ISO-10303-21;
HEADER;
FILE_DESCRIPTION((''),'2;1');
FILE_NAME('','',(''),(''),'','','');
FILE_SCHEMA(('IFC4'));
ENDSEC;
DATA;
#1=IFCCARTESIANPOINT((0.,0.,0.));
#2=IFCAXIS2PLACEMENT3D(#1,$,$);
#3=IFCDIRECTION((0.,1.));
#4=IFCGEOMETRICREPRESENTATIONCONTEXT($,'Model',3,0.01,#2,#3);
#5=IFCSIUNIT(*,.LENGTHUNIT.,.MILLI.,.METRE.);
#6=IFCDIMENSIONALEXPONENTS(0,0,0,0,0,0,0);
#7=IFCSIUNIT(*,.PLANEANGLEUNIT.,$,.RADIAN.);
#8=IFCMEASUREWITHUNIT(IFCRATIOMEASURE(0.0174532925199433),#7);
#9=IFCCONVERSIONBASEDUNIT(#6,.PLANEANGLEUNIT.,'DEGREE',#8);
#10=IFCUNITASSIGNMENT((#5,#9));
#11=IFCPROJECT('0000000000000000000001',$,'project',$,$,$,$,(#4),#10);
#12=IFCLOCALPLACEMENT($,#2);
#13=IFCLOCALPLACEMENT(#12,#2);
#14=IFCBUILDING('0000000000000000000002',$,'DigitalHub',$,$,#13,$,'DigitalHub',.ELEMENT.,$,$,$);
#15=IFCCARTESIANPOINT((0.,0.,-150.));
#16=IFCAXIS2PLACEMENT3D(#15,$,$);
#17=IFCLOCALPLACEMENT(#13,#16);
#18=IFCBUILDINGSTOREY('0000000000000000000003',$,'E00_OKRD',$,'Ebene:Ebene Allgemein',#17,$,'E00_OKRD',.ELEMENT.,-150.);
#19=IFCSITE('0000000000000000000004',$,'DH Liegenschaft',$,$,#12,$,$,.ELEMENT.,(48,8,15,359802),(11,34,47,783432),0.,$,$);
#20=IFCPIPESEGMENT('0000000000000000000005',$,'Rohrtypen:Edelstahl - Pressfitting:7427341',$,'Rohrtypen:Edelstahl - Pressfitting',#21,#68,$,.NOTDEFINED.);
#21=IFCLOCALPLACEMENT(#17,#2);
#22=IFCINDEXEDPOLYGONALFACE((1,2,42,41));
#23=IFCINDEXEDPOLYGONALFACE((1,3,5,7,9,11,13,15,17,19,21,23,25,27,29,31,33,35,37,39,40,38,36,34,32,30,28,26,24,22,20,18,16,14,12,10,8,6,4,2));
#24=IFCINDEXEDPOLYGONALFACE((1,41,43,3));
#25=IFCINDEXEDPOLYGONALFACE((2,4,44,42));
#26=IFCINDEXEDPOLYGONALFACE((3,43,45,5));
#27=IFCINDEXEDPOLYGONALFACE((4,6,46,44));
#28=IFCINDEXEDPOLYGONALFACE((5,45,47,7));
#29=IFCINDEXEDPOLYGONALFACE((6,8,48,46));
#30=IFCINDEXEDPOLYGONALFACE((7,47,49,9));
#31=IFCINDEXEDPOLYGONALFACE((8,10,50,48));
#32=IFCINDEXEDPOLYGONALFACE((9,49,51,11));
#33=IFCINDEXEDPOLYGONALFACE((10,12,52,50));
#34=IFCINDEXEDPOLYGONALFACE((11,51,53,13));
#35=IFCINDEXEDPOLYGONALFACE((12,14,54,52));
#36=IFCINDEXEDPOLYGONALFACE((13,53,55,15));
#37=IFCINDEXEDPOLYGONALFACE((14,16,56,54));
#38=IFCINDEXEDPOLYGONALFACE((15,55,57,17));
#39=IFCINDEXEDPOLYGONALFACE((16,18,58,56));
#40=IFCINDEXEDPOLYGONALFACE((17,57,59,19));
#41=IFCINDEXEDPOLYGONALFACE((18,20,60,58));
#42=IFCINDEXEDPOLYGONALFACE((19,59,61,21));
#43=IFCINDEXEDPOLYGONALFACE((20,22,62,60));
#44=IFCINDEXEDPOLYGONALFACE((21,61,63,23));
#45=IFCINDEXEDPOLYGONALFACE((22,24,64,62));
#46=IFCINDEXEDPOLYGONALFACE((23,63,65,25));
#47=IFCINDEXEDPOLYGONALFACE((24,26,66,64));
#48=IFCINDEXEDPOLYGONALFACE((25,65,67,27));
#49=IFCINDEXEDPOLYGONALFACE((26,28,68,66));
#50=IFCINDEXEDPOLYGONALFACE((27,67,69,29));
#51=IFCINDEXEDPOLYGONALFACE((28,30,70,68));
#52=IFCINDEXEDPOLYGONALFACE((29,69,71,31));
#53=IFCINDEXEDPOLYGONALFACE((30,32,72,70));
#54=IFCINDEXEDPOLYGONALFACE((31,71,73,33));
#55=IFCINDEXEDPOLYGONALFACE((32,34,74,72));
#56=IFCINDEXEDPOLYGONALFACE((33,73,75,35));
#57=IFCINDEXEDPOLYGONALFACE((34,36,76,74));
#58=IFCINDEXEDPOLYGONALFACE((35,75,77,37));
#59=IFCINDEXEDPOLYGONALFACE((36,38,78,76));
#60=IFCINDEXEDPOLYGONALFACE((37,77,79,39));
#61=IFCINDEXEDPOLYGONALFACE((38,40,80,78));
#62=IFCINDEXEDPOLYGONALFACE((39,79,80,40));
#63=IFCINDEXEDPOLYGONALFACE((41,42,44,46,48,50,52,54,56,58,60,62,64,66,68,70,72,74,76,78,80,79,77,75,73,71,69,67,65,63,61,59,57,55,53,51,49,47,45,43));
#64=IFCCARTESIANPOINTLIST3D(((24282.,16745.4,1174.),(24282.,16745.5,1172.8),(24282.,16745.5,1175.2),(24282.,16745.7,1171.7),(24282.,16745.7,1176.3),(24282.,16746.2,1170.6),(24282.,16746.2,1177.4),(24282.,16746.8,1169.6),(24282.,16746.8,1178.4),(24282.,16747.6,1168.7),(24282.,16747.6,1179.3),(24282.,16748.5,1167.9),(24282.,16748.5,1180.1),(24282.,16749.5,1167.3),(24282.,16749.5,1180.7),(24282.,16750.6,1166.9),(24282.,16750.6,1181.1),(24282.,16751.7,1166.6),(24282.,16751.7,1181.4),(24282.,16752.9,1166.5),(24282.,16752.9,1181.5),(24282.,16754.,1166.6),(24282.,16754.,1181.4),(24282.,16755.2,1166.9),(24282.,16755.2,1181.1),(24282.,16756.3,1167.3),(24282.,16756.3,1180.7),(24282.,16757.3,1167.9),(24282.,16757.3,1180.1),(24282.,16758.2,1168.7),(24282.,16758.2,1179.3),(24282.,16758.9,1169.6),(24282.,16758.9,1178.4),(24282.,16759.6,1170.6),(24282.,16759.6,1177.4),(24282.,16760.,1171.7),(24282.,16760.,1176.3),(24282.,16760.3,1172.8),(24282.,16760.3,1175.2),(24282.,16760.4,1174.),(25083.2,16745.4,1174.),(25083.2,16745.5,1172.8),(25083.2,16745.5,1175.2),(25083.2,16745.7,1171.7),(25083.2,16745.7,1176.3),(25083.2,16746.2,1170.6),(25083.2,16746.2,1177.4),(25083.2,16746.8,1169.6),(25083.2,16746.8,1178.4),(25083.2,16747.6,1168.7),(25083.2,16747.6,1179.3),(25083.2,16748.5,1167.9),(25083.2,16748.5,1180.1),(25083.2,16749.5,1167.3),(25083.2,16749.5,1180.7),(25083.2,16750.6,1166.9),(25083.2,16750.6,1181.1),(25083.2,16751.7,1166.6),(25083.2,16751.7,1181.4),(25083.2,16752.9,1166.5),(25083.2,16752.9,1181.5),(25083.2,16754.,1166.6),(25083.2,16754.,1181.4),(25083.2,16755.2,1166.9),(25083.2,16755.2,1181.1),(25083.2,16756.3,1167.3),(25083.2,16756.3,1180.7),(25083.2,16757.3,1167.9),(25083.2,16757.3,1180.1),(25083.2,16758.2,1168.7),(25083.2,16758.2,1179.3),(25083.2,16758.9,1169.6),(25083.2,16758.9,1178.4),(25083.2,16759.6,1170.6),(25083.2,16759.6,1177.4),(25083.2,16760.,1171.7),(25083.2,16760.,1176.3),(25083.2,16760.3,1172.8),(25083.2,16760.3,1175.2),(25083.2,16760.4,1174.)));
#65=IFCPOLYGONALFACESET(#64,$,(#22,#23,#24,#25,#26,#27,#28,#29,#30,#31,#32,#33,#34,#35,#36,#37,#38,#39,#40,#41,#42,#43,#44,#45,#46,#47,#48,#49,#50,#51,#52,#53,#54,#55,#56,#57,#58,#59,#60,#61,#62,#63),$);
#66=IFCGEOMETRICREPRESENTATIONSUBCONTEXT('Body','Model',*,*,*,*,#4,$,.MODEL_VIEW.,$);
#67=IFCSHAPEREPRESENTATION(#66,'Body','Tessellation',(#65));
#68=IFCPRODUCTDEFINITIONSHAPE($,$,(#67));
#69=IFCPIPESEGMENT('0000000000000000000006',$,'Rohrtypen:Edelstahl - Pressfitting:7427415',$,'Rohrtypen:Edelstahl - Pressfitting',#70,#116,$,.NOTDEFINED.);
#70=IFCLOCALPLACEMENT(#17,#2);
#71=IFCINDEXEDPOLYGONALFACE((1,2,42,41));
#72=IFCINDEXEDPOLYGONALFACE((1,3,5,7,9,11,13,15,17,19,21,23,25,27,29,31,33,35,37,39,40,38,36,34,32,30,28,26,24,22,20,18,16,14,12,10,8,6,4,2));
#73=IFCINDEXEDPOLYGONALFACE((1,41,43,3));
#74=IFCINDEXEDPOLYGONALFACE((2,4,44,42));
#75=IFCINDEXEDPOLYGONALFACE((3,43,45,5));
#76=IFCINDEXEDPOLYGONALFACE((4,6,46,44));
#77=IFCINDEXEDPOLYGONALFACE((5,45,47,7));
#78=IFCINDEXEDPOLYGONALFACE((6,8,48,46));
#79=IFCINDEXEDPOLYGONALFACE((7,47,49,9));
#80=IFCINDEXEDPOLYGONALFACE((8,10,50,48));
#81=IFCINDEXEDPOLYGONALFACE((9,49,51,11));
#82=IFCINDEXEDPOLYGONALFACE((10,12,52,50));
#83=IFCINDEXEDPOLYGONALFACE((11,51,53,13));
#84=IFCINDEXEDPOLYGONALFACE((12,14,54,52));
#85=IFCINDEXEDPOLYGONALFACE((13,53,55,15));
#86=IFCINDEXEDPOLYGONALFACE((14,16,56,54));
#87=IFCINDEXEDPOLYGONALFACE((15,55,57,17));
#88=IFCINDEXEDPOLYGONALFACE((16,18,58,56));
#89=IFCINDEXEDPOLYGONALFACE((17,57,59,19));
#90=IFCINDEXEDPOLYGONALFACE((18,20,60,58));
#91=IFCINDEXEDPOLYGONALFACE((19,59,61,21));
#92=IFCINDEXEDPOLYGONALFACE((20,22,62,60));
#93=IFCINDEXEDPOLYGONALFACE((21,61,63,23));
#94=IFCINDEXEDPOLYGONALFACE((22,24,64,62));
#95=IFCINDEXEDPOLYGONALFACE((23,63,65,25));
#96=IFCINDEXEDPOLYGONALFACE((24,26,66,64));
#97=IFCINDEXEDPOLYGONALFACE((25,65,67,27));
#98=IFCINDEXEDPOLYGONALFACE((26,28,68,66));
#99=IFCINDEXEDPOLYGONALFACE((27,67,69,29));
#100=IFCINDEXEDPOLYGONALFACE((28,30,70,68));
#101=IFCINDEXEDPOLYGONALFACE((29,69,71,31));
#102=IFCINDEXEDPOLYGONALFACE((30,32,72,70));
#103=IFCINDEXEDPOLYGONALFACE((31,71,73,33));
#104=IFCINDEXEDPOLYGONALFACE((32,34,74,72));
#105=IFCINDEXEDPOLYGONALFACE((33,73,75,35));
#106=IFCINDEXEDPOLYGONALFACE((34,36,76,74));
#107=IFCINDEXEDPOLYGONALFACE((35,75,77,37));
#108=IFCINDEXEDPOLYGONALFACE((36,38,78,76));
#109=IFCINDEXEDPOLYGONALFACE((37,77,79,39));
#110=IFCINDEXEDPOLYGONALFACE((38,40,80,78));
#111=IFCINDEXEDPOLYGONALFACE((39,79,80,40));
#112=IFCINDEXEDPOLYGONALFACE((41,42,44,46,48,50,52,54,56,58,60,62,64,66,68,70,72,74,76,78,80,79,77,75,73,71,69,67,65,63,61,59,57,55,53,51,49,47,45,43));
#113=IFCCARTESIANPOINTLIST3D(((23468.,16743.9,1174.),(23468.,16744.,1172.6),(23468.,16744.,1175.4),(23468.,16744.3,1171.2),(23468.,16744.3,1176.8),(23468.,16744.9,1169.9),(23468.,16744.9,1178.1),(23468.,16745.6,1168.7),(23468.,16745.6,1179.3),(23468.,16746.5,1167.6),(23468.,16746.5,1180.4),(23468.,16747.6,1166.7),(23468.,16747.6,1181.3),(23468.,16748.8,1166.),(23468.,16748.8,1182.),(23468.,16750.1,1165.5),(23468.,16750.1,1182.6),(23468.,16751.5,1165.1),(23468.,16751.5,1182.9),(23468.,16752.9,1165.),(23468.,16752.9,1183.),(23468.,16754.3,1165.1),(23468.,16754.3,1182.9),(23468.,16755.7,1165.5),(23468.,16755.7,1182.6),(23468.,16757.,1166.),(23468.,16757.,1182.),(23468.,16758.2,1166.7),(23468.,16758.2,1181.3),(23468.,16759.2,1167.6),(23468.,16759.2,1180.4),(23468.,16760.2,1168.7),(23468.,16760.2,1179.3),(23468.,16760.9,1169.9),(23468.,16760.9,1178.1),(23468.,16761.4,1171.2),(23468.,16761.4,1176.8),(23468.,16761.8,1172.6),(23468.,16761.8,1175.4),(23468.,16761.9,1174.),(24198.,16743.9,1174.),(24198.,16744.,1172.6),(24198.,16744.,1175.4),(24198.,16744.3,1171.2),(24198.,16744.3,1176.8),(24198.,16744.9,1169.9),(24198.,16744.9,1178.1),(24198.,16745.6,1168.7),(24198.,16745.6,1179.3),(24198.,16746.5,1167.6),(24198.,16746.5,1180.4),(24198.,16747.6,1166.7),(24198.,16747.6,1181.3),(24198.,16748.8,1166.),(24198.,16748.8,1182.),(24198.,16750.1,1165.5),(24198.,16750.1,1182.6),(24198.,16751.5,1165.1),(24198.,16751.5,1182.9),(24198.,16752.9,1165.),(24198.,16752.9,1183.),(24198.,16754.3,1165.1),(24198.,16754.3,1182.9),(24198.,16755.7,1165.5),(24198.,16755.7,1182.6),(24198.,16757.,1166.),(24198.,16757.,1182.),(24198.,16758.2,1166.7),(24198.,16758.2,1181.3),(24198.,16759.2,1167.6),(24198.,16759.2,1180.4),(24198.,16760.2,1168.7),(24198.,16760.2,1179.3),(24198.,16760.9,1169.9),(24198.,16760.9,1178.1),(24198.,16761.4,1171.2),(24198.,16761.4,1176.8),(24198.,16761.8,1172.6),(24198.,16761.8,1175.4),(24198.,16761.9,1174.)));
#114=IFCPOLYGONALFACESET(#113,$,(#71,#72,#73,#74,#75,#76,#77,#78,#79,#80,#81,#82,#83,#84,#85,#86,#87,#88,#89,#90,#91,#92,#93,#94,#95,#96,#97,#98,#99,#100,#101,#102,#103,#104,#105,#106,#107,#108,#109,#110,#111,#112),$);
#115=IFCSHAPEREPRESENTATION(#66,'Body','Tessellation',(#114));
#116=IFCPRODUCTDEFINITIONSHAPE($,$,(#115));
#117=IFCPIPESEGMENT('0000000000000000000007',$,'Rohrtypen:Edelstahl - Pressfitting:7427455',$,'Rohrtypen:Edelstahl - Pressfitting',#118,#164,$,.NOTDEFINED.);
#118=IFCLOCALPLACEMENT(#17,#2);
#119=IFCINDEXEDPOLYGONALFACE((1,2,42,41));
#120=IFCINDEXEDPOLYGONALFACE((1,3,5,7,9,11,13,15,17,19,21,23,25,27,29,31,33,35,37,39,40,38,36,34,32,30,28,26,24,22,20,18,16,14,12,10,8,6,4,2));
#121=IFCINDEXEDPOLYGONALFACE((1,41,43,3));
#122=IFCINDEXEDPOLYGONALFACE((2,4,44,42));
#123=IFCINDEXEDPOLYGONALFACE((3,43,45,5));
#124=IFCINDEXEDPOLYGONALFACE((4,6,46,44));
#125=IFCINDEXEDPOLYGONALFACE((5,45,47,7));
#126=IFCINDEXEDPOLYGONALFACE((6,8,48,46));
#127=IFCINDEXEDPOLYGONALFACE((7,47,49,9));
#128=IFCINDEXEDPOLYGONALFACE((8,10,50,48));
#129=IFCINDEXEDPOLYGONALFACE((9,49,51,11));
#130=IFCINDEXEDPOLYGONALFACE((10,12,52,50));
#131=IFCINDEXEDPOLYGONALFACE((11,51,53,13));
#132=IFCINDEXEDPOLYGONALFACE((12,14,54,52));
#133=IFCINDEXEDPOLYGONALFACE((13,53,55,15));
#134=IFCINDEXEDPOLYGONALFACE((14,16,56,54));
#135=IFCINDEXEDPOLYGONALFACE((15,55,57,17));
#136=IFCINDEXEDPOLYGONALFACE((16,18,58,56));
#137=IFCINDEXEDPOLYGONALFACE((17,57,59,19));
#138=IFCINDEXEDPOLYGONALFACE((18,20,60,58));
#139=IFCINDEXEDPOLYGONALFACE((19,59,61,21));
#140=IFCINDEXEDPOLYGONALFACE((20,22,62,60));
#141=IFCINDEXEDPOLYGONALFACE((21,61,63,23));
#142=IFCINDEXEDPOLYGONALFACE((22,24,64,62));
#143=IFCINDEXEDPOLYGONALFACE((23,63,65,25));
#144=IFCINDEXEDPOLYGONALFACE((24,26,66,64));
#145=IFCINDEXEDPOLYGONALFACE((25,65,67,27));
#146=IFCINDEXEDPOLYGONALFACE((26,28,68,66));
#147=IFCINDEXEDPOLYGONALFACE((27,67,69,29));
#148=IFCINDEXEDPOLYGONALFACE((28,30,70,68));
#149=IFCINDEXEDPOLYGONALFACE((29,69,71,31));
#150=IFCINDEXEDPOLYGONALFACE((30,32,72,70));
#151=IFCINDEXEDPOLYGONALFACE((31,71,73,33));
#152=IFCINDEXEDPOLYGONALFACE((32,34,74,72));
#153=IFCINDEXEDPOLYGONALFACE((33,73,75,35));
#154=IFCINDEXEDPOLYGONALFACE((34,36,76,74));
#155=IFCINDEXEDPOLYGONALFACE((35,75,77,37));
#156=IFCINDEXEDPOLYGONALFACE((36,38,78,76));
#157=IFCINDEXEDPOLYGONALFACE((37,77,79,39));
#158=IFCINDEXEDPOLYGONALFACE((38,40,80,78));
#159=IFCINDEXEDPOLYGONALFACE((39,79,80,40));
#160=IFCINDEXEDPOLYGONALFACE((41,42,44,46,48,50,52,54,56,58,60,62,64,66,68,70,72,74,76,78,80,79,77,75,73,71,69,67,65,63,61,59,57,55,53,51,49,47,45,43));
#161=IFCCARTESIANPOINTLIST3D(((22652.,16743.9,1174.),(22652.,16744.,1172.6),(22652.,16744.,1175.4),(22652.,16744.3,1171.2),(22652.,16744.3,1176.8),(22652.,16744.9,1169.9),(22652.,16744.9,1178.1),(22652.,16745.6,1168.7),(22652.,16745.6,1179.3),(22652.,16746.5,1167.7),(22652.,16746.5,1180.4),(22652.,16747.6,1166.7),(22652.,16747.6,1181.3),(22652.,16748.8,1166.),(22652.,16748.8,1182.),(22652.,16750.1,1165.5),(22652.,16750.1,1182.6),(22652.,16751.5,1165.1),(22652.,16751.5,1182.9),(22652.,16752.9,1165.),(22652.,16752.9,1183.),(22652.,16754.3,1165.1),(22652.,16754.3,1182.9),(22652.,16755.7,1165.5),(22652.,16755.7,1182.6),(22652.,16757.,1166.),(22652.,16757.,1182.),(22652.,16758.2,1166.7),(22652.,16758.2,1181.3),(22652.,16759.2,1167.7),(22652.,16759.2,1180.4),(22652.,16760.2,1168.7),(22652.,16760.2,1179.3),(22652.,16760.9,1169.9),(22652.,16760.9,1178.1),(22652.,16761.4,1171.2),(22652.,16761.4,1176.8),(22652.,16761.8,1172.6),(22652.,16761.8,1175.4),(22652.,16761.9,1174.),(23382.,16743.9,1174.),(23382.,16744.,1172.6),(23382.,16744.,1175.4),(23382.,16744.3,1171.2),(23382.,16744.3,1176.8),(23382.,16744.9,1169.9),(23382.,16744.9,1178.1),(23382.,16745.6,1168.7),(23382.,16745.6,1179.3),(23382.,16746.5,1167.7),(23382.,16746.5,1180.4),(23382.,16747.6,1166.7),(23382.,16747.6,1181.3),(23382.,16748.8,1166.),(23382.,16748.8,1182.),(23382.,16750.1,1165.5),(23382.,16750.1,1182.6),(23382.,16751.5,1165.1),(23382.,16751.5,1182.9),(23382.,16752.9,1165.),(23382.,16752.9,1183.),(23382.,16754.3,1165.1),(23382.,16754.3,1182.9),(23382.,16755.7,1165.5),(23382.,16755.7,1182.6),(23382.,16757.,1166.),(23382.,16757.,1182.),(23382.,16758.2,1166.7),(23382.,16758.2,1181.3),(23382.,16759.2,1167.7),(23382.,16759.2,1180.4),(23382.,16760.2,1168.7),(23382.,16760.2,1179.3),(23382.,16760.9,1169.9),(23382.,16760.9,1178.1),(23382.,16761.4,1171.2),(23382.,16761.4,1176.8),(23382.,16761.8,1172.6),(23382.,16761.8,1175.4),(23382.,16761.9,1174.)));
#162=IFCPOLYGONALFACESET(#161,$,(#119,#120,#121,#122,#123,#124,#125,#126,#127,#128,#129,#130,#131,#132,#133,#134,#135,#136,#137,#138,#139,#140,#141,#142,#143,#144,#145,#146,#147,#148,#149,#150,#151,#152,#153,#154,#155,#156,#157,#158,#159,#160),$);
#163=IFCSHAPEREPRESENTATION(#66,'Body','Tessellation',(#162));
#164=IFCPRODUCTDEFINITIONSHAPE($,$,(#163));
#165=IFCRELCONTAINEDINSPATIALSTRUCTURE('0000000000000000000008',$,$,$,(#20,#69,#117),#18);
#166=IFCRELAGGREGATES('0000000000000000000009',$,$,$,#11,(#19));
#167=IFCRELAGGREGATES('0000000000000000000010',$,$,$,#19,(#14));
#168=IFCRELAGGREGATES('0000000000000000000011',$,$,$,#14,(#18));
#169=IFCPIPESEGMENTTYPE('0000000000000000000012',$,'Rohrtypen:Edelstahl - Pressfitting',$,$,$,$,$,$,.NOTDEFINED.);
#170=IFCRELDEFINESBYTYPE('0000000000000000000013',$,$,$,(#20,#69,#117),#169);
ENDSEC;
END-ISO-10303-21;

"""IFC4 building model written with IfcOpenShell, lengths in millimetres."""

from ifc_helpers import new_model, entity, si_unit, converted_unit, direction, frame, origin, place, context, subcontext, project, spatial, indexed_curve, outline, extrude, type_object, element, save


model = new_model("IFC4")

# Units and contexts
model_context = context("Model", 3, precision=0.01, world=origin(), true_north=direction((0.0, 1.0)))
body_context = subcontext(model_context, "Body", "Model", "MODEL_VIEW")
ifc_project = project(units=[si_unit("LENGTHUNIT", "METRE", prefix="MILLI"), converted_unit("PLANEANGLEUNIT", "DEGREE", entity("IfcRatioMeasure", 0.0174532925199433), si_unit("PLANEANGLEUNIT", "RADIAN"), dimensions=[0, 0, 0, 0, 0, 0, 0])], contexts=[model_context])

# Site, building, storey
site_placement = place(None, origin())
site = spatial("IfcSite", under=ifc_project, at=site_placement, Name="DH Liegenschaft", CompositionType="ELEMENT", RefLatitude=(48, 8, 15, 359802), RefLongitude=(11, 34, 47, 783432), RefElevation=0.0)
building_placement = place(site_placement, origin())
building = spatial("IfcBuilding", under=site, at=building_placement, Name="DigitalHub", LongName="DigitalHub", CompositionType="ELEMENT")
storey_placement = place(building_placement, frame((0.0, 0.0, -150.0)))
storey = spatial("IfcBuildingStorey", under=building, at=storey_placement, Name="E00_OKRD", ObjectType="Ebene:Ebene Allgemein", LongName="E00_OKRD", CompositionType="ELEMENT", Elevation=-150.0)

# Pipe segments
pipe_segment_type_1 = type_object("IfcPipeSegmentType", Name="Rohrtypen:Edelstahl - Pressfitting", PredefinedType="NOTDEFINED")
pipe_segment_1_placement = place(storey_placement, frame((24282.0, 16743.8, 1164.9)))
element("IfcPipeSegment", 1, at=pipe_segment_1_placement, inside=storey, type_object=pipe_segment_type_1, Name="Rohrtypen:Edelstahl - Pressfitting:7427341", ObjectType="Rohrtypen:Edelstahl - Pressfitting", PredefinedType="NOTDEFINED", context=body_context, shape_type="SweptSolid", body=[
    extrude(outline(indexed_curve([(7.5, 0.0), (7.4, 1.2), (7.1, 2.3), (6.7, 3.4), (6.1, 4.4), (5.3, 5.3), (4.4, 6.1), (3.4, 6.7), (2.3, 7.1), (1.2, 7.4), (0.0, 7.5), (-1.2, 7.4), (-2.3, 7.1), (-3.4, 6.7), (-4.4, 6.1), (-5.3, 5.3), (-6.1, 4.4), (-6.7, 3.4), (-7.1, 2.3), (-7.4, 1.2), (-7.5, 0.0), (-7.4, -1.2), (-7.1, -2.3), (-6.7, -3.4), (-6.1, -4.4), (-5.3, -5.3), (-4.4, -6.1), (-3.4, -6.7), (-2.3, -7.1), (-1.2, -7.4), (0.0, -7.5), (1.2, -7.4), (2.3, -7.1), (3.4, -6.7), (4.4, -6.1), (5.3, -5.3), (6.1, -4.4), (6.7, -3.4), (7.1, -2.3), (7.4, -1.2), (7.5, 0.0)], self_intersect=False)), frame((801.3, 9.1, 9.1), z_axis=(-1.0, 0.0, 0.000011), x_axis=(0.0, 1.0, 0.0)), (0.0, 0.0, 1.0), 801.3),
])
pipe_segment_2_placement = place(storey_placement, frame((23468.0, 16742.3, 1163.4)))
element("IfcPipeSegment", 2, at=pipe_segment_2_placement, inside=storey, type_object=pipe_segment_type_1, Name="Rohrtypen:Edelstahl - Pressfitting:7427415", ObjectType="Rohrtypen:Edelstahl - Pressfitting", PredefinedType="NOTDEFINED", context=body_context, shape_type="SweptSolid", body=[
    extrude(outline(indexed_curve([(9.0, 0.0), (8.9, 1.4), (8.6, 2.8), (8.0, 4.1), (7.3, 5.3), (6.4, 6.4), (5.3, 7.3), (4.1, 8.0), (2.8, 8.6), (1.4, 8.9), (0.0, 9.0), (-1.4, 8.9), (-2.8, 8.6), (-4.1, 8.0), (-5.3, 7.3), (-6.4, 6.4), (-7.3, 5.3), (-8.0, 4.1), (-8.6, 2.8), (-8.9, 1.4), (-9.0, 0.0), (-8.9, -1.4), (-8.6, -2.8), (-8.0, -4.1), (-7.3, -5.3), (-6.4, -6.4), (-5.3, -7.3), (-4.1, -8.0), (-2.8, -8.6), (-1.4, -8.9), (0.0, -9.0), (1.4, -8.9), (2.8, -8.6), (4.1, -8.0), (5.3, -7.3), (6.4, -6.4), (7.3, -5.3), (8.0, -4.1), (8.6, -2.8), (8.9, -1.4), (9.0, 0.0)], self_intersect=False)), frame((0.0, 10.6, 10.6), z_axis=(1.0, 0.0, 0.0), x_axis=(0.0, 1.0, 0.0)), (0.0, 0.0, 1.0), 730.0),
])
pipe_segment_3_placement = place(storey_placement, frame((22652.0, 16742.3, 1163.4)))
element("IfcPipeSegment", 3, at=pipe_segment_3_placement, inside=storey, type_object=pipe_segment_type_1, Name="Rohrtypen:Edelstahl - Pressfitting:7427455", ObjectType="Rohrtypen:Edelstahl - Pressfitting", PredefinedType="NOTDEFINED", context=body_context, shape_type="SweptSolid", body=[
    extrude(outline(indexed_curve([(9.0, 0.0), (8.9, 1.4), (8.6, 2.8), (8.0, 4.1), (7.3, 5.3), (6.4, 6.4), (5.3, 7.3), (4.1, 8.0), (2.8, 8.6), (1.4, 8.9), (0.0, 9.0), (-1.4, 8.9), (-2.8, 8.6), (-4.1, 8.0), (-5.3, 7.3), (-6.4, 6.4), (-7.3, 5.3), (-8.0, 4.1), (-8.6, 2.8), (-8.9, 1.4), (-9.0, 0.0), (-8.9, -1.4), (-8.6, -2.8), (-8.0, -4.1), (-7.3, -5.3), (-6.4, -6.4), (-5.3, -7.3), (-4.1, -8.0), (-2.8, -8.6), (-1.4, -8.9), (0.0, -9.0), (1.4, -8.9), (2.8, -8.6), (4.1, -8.0), (5.3, -7.3), (6.4, -6.4), (7.3, -5.3), (8.0, -4.1), (8.6, -2.8), (8.9, -1.4), (9.0, 0.0)], self_intersect=False)), frame((0.0, 10.6, 10.6), z_axis=(1.0, 0.0, 0.0), x_axis=(0.0, 1.0, 0.0)), (0.0, 0.0, 1.0), 730.0),
])

save(model, "model.ifc")
